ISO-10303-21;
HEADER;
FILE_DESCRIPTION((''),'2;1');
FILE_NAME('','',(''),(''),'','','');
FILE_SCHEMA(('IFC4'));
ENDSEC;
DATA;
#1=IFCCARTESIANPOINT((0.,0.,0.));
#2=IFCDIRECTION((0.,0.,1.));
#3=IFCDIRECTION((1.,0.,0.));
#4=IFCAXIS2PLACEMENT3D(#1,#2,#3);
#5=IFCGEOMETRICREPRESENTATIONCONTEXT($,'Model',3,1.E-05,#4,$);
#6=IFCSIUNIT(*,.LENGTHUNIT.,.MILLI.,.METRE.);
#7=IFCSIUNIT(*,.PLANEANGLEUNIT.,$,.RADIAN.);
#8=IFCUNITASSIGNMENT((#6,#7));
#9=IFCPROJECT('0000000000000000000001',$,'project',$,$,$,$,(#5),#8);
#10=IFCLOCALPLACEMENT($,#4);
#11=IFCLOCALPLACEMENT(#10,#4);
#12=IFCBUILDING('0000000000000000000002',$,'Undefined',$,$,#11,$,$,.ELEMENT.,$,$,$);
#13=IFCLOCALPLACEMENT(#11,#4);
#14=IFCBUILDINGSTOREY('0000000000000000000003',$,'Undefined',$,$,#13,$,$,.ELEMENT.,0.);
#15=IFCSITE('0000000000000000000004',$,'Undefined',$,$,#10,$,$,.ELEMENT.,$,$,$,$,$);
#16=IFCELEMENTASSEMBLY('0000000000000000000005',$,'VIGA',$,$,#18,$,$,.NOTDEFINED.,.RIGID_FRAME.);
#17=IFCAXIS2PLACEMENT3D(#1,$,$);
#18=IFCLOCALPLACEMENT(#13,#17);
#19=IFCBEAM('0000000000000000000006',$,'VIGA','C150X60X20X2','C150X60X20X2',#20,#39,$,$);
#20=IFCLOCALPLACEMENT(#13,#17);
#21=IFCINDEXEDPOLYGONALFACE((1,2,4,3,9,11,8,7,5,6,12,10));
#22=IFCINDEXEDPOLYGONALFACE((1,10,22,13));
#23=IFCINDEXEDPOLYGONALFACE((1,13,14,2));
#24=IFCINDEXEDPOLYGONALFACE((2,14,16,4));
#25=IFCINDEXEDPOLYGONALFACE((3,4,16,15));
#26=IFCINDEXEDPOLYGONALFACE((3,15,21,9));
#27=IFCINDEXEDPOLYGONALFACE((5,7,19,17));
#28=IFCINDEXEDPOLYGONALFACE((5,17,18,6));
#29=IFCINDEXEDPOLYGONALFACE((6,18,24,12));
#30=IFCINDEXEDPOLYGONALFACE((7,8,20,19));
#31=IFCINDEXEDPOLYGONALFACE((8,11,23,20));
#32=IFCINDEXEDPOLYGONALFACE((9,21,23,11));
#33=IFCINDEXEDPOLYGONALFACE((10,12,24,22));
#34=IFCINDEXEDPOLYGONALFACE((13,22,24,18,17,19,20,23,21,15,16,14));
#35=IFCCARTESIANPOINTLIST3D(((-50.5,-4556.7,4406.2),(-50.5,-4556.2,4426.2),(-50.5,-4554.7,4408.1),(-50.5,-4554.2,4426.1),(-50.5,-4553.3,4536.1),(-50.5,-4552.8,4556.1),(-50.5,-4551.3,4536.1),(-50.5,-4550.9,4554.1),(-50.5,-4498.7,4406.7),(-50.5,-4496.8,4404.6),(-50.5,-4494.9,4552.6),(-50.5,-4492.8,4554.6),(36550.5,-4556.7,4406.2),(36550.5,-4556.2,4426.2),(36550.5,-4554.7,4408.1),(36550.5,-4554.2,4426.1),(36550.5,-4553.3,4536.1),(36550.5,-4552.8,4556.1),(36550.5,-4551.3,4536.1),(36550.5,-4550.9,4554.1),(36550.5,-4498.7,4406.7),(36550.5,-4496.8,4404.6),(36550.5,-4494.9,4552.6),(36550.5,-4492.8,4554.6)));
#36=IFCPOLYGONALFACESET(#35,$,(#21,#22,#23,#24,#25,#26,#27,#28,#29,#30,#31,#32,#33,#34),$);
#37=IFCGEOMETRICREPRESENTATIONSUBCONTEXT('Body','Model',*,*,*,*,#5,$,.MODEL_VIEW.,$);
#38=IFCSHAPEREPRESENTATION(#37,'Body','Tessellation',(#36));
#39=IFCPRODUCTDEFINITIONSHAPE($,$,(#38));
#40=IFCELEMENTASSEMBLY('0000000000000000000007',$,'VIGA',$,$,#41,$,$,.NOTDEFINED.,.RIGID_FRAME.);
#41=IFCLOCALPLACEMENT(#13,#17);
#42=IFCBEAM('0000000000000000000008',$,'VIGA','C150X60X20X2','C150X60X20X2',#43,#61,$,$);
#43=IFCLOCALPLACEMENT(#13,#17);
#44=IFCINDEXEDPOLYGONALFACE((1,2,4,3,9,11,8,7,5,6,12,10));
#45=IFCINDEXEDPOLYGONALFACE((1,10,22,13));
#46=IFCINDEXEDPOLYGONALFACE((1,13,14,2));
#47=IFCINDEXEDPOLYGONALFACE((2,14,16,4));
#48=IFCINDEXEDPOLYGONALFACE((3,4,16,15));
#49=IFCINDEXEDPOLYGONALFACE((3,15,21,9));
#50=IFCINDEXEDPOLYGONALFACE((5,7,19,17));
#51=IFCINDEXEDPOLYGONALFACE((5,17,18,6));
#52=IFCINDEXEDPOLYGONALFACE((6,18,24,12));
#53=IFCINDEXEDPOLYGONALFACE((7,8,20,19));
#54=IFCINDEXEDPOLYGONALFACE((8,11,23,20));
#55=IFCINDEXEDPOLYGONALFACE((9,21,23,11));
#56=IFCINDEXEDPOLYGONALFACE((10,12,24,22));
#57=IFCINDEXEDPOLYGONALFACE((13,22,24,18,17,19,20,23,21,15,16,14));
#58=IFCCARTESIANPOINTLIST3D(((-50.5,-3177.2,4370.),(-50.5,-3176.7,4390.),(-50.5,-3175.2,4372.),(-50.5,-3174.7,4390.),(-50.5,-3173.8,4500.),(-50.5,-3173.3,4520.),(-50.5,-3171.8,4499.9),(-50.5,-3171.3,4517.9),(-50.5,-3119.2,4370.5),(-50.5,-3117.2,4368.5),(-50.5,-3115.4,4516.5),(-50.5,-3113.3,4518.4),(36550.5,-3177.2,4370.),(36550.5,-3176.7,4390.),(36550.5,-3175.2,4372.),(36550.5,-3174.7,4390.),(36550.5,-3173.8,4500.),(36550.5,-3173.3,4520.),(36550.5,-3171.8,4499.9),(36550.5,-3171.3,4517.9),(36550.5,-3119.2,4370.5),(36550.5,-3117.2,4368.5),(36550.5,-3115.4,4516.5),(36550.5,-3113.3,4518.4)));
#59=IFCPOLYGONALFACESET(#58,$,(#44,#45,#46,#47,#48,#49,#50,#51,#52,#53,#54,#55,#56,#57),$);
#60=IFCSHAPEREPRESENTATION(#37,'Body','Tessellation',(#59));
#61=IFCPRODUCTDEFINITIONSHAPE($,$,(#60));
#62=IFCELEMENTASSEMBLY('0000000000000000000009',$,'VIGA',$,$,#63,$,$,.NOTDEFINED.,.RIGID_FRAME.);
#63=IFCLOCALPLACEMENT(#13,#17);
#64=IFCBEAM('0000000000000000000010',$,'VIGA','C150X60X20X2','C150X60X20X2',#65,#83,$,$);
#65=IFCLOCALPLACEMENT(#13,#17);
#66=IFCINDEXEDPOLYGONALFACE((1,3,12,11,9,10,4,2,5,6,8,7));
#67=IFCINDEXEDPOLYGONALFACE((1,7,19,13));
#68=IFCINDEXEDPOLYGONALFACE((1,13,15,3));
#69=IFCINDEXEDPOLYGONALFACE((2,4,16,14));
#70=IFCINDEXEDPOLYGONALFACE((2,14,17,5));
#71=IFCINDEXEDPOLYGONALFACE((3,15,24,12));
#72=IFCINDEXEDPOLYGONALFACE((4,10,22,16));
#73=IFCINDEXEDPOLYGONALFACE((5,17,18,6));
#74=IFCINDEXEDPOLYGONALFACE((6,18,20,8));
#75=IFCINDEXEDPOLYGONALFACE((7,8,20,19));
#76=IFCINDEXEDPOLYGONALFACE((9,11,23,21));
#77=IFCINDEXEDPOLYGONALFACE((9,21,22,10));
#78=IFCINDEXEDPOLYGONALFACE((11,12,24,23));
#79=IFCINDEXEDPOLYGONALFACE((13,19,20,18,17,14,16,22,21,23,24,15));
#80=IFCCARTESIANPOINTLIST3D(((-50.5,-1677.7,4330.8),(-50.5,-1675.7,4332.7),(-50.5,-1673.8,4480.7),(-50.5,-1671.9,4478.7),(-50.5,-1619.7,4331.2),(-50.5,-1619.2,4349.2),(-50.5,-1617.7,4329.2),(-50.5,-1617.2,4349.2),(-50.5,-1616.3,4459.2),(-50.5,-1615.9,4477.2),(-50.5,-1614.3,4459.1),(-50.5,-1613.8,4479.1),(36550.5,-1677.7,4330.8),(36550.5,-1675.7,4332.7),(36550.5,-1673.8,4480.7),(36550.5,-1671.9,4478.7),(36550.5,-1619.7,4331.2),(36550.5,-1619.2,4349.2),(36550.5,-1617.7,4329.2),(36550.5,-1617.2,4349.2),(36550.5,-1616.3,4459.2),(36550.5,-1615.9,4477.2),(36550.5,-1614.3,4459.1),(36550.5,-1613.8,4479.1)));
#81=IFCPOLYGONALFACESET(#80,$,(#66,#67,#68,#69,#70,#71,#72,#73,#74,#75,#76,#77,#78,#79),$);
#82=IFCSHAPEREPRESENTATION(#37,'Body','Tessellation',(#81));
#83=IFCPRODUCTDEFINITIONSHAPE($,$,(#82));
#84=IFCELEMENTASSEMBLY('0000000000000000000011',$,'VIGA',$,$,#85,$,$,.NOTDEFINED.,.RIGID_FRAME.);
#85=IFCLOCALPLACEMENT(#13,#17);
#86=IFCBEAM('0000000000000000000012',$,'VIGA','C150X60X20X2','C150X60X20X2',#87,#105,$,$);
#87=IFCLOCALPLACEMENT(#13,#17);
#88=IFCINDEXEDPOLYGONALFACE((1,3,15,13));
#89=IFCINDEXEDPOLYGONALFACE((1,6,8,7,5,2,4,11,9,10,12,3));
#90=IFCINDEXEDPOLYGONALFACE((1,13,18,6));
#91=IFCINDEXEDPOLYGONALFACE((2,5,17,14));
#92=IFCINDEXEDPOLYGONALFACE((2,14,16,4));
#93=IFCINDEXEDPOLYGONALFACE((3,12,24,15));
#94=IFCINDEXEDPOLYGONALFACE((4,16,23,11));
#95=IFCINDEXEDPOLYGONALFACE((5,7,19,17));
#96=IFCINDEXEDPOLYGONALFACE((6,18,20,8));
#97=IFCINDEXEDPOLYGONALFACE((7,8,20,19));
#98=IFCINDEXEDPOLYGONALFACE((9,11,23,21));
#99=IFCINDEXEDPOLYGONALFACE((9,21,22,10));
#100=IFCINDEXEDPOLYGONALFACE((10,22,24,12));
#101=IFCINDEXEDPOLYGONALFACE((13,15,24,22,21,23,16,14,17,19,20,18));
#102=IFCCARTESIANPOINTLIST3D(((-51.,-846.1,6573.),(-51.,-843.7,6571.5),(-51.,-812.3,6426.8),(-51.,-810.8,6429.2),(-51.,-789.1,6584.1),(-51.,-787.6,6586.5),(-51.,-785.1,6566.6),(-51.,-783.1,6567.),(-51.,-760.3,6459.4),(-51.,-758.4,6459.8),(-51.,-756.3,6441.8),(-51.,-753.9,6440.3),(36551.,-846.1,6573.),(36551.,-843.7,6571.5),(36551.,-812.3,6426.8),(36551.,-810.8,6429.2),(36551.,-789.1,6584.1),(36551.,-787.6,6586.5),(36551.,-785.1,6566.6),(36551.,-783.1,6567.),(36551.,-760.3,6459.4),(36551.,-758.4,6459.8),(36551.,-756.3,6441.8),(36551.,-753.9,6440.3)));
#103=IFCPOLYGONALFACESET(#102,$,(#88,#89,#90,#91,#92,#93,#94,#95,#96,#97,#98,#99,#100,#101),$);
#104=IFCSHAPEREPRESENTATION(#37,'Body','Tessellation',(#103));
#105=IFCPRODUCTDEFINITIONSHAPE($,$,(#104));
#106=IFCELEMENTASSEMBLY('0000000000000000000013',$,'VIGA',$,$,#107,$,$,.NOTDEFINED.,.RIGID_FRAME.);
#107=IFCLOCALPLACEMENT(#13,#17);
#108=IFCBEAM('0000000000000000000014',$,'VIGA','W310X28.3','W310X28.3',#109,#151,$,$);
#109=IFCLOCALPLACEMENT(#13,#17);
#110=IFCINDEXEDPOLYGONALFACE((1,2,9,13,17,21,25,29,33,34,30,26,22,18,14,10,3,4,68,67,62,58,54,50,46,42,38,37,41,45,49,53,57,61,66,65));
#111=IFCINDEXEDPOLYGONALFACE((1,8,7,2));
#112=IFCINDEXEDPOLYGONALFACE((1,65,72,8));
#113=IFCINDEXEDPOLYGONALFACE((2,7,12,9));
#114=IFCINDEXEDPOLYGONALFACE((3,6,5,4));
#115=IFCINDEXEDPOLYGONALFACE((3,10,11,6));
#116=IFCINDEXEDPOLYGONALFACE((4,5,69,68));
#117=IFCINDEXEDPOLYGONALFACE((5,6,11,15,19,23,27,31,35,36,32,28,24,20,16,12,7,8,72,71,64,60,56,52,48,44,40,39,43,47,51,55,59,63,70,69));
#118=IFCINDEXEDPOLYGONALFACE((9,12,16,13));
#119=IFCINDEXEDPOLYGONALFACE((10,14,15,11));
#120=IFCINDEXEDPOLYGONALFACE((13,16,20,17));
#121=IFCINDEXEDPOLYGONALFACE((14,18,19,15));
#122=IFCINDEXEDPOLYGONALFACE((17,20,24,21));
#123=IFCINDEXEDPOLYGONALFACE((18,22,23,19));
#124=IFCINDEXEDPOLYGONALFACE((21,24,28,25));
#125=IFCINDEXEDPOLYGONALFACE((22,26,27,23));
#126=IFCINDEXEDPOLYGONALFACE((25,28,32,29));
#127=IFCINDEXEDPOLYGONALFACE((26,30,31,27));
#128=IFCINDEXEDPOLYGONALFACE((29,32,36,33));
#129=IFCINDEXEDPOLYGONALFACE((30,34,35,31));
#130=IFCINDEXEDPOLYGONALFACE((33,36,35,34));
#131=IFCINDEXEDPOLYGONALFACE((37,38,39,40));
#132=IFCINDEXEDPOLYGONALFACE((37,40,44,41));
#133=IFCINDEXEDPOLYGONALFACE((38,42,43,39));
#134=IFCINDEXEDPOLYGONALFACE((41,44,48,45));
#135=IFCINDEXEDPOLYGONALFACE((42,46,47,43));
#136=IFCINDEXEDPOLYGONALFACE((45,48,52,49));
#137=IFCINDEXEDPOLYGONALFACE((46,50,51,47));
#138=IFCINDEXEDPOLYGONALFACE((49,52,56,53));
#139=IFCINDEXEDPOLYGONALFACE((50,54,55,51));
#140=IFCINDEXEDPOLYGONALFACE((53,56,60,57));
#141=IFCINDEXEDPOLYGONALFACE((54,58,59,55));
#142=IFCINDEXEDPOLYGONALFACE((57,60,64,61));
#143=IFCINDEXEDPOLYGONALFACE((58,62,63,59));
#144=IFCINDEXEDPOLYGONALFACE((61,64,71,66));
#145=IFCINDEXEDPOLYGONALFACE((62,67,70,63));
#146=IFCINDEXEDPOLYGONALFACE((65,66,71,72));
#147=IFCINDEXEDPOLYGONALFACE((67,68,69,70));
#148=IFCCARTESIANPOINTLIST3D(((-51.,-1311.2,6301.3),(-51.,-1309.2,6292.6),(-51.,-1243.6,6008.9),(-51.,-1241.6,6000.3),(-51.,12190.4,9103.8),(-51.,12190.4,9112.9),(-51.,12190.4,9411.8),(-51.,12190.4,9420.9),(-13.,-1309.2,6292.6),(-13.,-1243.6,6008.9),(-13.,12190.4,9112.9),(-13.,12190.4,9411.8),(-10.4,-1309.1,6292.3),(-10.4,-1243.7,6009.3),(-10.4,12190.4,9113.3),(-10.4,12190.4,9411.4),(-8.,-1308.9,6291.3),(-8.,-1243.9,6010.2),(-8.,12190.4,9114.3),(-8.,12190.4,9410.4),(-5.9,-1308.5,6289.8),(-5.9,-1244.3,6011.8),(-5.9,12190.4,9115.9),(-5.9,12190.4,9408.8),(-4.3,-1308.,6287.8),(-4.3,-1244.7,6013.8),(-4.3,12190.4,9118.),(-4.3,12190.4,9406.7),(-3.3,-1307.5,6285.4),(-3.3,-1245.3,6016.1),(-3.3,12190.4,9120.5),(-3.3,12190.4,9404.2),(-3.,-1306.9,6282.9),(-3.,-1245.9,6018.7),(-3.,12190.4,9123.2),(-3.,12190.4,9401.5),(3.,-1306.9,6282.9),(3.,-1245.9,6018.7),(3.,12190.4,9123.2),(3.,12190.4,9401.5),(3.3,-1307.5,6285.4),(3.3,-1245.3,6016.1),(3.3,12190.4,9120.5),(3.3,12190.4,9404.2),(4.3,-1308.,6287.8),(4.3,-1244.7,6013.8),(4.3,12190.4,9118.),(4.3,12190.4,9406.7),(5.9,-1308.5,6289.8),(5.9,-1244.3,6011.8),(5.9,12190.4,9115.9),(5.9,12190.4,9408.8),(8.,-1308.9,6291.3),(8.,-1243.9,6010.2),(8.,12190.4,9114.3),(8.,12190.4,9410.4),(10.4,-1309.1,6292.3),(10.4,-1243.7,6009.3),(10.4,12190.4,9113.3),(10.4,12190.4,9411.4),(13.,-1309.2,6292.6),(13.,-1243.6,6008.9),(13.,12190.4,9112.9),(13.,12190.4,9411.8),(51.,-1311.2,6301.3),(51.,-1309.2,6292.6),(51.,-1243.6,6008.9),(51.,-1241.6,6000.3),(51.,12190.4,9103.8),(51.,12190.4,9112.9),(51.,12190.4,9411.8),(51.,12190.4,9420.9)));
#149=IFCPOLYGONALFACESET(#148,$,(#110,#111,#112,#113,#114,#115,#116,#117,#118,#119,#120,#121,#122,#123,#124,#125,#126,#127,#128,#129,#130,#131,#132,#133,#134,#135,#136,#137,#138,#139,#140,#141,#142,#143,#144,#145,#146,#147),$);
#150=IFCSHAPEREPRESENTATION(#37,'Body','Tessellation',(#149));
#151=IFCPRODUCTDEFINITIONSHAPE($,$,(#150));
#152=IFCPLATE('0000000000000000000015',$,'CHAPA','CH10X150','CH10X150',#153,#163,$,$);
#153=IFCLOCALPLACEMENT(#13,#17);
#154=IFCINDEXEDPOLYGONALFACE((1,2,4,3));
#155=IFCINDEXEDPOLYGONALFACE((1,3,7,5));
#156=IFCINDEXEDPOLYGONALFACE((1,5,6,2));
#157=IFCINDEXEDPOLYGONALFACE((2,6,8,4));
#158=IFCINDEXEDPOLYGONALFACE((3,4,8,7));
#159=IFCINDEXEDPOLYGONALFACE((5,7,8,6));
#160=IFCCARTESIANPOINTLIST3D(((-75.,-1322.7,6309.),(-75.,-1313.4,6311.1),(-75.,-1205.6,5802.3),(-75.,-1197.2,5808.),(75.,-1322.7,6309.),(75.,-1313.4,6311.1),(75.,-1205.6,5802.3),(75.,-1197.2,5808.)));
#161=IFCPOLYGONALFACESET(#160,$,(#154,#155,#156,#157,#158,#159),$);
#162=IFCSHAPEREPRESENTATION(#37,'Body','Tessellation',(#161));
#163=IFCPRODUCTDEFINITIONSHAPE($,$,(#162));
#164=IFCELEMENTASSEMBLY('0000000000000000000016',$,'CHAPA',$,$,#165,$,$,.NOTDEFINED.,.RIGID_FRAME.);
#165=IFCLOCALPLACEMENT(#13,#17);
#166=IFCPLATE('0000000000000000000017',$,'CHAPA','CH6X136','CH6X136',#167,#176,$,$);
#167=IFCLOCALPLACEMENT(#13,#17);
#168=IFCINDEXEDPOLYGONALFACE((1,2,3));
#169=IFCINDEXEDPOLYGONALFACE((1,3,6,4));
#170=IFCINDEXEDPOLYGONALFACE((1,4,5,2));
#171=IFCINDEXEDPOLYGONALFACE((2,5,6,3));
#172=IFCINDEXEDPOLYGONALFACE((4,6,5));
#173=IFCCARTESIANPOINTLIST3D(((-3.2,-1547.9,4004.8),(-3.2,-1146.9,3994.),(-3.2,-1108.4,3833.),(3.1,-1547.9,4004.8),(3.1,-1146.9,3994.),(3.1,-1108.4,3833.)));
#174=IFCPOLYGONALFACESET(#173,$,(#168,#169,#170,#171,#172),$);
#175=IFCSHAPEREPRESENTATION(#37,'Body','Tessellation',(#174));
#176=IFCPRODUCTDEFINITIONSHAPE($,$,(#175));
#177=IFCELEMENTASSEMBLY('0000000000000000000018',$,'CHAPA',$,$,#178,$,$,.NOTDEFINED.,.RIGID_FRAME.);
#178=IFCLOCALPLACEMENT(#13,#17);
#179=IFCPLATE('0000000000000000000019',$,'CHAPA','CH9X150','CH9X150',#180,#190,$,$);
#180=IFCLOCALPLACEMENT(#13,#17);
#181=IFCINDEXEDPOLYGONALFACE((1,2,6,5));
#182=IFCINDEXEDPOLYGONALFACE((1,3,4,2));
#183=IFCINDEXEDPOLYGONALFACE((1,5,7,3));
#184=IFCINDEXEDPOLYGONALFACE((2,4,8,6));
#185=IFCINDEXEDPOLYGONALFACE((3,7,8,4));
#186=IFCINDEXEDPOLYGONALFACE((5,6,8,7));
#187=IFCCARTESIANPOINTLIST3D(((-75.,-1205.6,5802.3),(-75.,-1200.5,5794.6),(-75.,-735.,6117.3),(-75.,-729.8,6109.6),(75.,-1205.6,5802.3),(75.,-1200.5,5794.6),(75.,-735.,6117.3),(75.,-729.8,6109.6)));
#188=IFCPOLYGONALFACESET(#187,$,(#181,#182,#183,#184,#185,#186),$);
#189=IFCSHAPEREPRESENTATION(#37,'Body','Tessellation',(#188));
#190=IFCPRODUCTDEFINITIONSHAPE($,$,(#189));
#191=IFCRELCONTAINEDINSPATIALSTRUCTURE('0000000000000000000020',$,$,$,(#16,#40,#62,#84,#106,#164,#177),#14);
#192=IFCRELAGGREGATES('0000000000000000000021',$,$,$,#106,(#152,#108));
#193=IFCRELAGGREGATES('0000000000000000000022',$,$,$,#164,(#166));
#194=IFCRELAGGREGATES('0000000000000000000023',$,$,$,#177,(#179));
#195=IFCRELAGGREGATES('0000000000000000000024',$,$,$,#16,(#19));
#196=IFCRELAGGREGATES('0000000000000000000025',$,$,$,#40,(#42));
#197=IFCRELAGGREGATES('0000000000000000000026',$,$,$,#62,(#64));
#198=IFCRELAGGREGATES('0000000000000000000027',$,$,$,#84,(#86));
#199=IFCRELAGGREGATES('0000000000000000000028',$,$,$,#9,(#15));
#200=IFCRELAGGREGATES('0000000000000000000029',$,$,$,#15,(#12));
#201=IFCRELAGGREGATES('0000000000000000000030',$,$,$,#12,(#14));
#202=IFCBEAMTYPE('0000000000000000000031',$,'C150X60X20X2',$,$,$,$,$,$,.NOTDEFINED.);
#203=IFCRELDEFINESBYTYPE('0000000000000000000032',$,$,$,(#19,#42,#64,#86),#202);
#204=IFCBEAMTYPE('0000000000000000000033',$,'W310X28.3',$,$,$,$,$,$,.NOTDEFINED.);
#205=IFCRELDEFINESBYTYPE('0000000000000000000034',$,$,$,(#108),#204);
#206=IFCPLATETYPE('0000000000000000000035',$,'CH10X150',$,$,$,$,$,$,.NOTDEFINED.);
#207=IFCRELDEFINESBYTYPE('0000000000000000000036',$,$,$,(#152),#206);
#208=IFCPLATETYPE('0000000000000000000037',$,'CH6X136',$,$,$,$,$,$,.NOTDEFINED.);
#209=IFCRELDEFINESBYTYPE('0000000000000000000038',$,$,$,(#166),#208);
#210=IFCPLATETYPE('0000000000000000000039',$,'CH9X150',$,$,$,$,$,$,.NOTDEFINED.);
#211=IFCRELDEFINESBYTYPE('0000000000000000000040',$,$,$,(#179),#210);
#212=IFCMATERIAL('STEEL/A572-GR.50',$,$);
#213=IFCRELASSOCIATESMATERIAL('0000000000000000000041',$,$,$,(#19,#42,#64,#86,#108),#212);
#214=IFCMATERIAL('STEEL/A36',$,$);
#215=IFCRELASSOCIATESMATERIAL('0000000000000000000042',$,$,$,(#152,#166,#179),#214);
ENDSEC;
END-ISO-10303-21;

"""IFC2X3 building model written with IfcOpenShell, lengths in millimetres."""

from ifc_helpers import new_model, si_unit, frame, origin_with_axes, origin_2d_with_axis, place, context, subcontext, project, spatial, polyline, i_section, c_section, outline, extrude, clip, halfspace, material, type_object, element, aggregate, save


model = new_model("IFC2X3")

# Units and contexts
model_context = context("Model", 3, precision=1e-05, world=origin_with_axes())
body_context = subcontext(model_context, "Body", "Model", "MODEL_VIEW")
ifc_project = project(units=[si_unit("LENGTHUNIT", "METRE", prefix="MILLI"), si_unit("PLANEANGLEUNIT", "RADIAN")], contexts=[model_context])

# Site, building, storey
site_placement = place(None, origin_with_axes())
site = spatial("IfcSite", under=ifc_project, at=site_placement, Name="Undefined", CompositionType="ELEMENT")
building_placement = place(site_placement, origin_with_axes())
building = spatial("IfcBuilding", under=site, at=building_placement, Name="Undefined", CompositionType="ELEMENT")
storey_placement = place(building_placement, origin_with_axes())
storey = spatial("IfcBuildingStorey", under=building, at=storey_placement, Name="Undefined", CompositionType="ELEMENT", Elevation=0.0)

# Element assemblies, beams
assembly_1_placement = place(storey_placement, origin_with_axes())
assembly_1 = element("IfcElementAssembly", 1, at=assembly_1_placement, inside=storey, Name="VIGA", AssemblyPlace="NOTDEFINED", PredefinedType="RIGID_FRAME")
ifc_material_1 = material(Name="STEEL/A572-GR.50")
beam_type_1 = type_object("IfcBeamType", Name="C150X60X20X2", PredefinedType="NOTDEFINED")
beam_1_placement = place(assembly_1_placement, frame((-50.5, -4524.8, 4480.4), z_axis=(0.0, 0.026187, 0.999657), x_axis=(1.0, 0.0, 0.0)))
beam_1 = element("IfcBeam", 2, at=beam_1_placement, type_object=beam_type_1, material=ifc_material_1, Name="VIGA", Description="C150X60X20X2", ObjectType="C150X60X20X2", context=body_context, shape_type="SweptSolid", body=[
    extrude(c_section(Depth=150.0, Width=60.0, WallThickness=2.0, Girth=20.0, at=origin_2d_with_axis()), frame((36601.0, 0.0, 0.0), z_axis=(-1.0, 0.0, 0.0), x_axis=(0.0, -1.0, 0.0)), (0.0, 0.0, 1.0), 36601.0),
])
assembly_2_placement = place(storey_placement, origin_with_axes())
assembly_2 = element("IfcElementAssembly", 3, at=assembly_2_placement, inside=storey, Name="VIGA", AssemblyPlace="NOTDEFINED", PredefinedType="RIGID_FRAME")
beam_2_placement = place(assembly_2_placement, frame((-50.5, -3145.3, 4444.2), z_axis=(0.0, 0.026187, 0.999657), x_axis=(1.0, 0.0, 0.0)))
beam_2 = element("IfcBeam", 4, at=beam_2_placement, type_object=beam_type_1, material=ifc_material_1, Name="VIGA", Description="C150X60X20X2", ObjectType="C150X60X20X2", context=body_context, shape_type="SweptSolid", body=[
    extrude(c_section(Depth=150.0, Width=60.0, WallThickness=2.0, Girth=20.0, at=origin_2d_with_axis()), frame((36601.0, 0.0, 0.0), z_axis=(-1.0, 0.0, 0.0), x_axis=(0.0, -1.0, 0.0)), (0.0, 0.0, 1.0), 36601.0),
])
assembly_3_placement = place(storey_placement, origin_with_axes())
assembly_3 = element("IfcElementAssembly", 5, at=assembly_3_placement, inside=storey, Name="VIGA", AssemblyPlace="NOTDEFINED", PredefinedType="RIGID_FRAME")
beam_3_placement = place(assembly_3_placement, frame((-50.5, -1645.8, 4404.9), z_axis=(0.0, -0.026187, -0.999657), x_axis=(1.0, 0.0, 0.0)))
beam_3 = element("IfcBeam", 6, at=beam_3_placement, type_object=beam_type_1, material=ifc_material_1, Name="VIGA", Description="C150X60X20X2", ObjectType="C150X60X20X2", context=body_context, shape_type="SweptSolid", body=[
    extrude(c_section(Depth=150.0, Width=60.0, WallThickness=2.0, Girth=20.0, at=origin_2d_with_axis()), frame((36601.0, 0.0, 0.0), z_axis=(-1.0, 0.0, 0.0), x_axis=(0.0, -1.0, 0.0)), (0.0, 0.0, 1.0), 36601.0),
])
assembly_4_placement = place(storey_placement, origin_with_axes())
assembly_4 = element("IfcElementAssembly", 7, at=assembly_4_placement, inside=storey, Name="VIGA", AssemblyPlace="NOTDEFINED", PredefinedType="RIGID_FRAME")
beam_4_placement = place(assembly_4_placement, frame((-51.0, -800.0, 6506.7), z_axis=(0.0, 0.225124, -0.97433), x_axis=(1.0, 0.0, 0.0)))
beam_4 = element("IfcBeam", 8, at=beam_4_placement, type_object=beam_type_1, material=ifc_material_1, Name="VIGA", Description="C150X60X20X2", ObjectType="C150X60X20X2", context=body_context, shape_type="SweptSolid", body=[
    extrude(c_section(Depth=150.0, Width=60.0, WallThickness=2.0, Girth=20.0, at=origin_2d_with_axis()), frame((36602.0, 0.0, 0.0), z_axis=(-1.0, 0.0, 0.0), x_axis=(0.0, -1.0, 0.0)), (0.0, 0.0, 1.0), 36602.0),
])
assembly_5_placement = place(storey_placement, origin_with_axes())
assembly_5 = element("IfcElementAssembly", 9, at=assembly_5_placement, inside=storey, Name="VIGA", AssemblyPlace="NOTDEFINED", PredefinedType="RIGID_FRAME")
beam_type_2 = type_object("IfcBeamType", Name="W310X28.3", PredefinedType="NOTDEFINED")
beam_5_placement = place(assembly_5_placement, frame((0.0, -1276.4, 6150.8), z_axis=(0.0, 0.225124, -0.97433), x_axis=(0.0, 0.97433, 0.225124)))
beam_5 = element("IfcBeam", 10, at=beam_5_placement, type_object=beam_type_2, material=ifc_material_1, Name="VIGA", Description="W310X28.3", ObjectType="W310X28.3", context=body_context, shape_type="Clipping", body=[
    clip(extrude(i_section(OverallWidth=102.0, OverallDepth=309.0, WebThickness=6.0, FlangeThickness=8.9, FilletRadius=10.0, at=origin_2d_with_axis()), frame((13995.7, 0.0, 0.0), z_axis=(-1.0, 0.0, 0.0), x_axis=(0.0, -1.0, 0.0)), (0.0, 0.0, 1.0), 13995.7), halfspace(frame((13857.8, 0.0, -156.7), z_axis=(0.97433, 0.0, 0.225124), x_axis=(-0.225124, 0.0, 0.97433)), False)),
])

# Plate
ifc_material_2 = material(Name="STEEL/A36")
plate_type_1 = type_object("IfcPlateType", Name="CH10X150", PredefinedType="NOTDEFINED")
plate_1_placement = place(assembly_5_placement, frame((75.0, -1318.1, 6310.1), z_axis=(0.0, 0.97433, 0.225124), x_axis=(0.0, 0.225124, -0.97433)))
plate_1 = element("IfcPlate", 11, at=plate_1_placement, type_object=plate_type_1, material=ifc_material_2, Name="CHAPA", Description="CH10X150", ObjectType="CH10X150", context=body_context, shape_type="Clipping", body=[
    clip(extrude(outline(polyline([(0.0, 0.0), (520.0, 0.0), (520.0, 150.0), (0.0, 150.0), (0.0, 0.0)])), frame((0.0, 0.0, -4.8), z_axis=(0.0, 0.0, 1.0), x_axis=(1.0, 0.0, 0.0)), (0.0, 0.0, 1.0), 9.5), halfspace(frame((516.4, -500.0, 4.8), z_axis=(0.934951, 0.0, 0.354778), x_axis=(0.0, 1.0, 0.0)), False)),
])
aggregate(assembly_5, [plate_1, beam_5])

# Element assemblies, plates
assembly_6_placement = place(storey_placement, origin_with_axes())
assembly_6 = element("IfcElementAssembly", 12, at=assembly_6_placement, inside=storey, Name="CHAPA", AssemblyPlace="NOTDEFINED", PredefinedType="RIGID_FRAME")
plate_type_2 = type_object("IfcPlateType", Name="CH6X136", PredefinedType="NOTDEFINED")
plate_2_placement = place(assembly_6_placement, frame((0.0, -1146.9, 3994.0), z_axis=(1.0, 0.0, 0.0), x_axis=(0.0, -0.999636, 0.026972)))
plate_2 = element("IfcPlate", 13, at=plate_2_placement, type_object=plate_type_2, material=ifc_material_2, Name="CHAPA", Description="CH6X136", ObjectType="CH6X136", context=body_context, shape_type="SweptSolid", body=[
    extrude(outline(polyline([(0.0, 0.0), (401.1, 0.0), (-42.8, 159.9), (0.0, 0.0)])), frame((0.0, 0.0, -3.1), z_axis=(0.0, 0.0, 1.0), x_axis=(1.0, 0.0, 0.0)), (0.0, 0.0, 1.0), 6.3),
])
aggregate(assembly_6, [plate_2])
assembly_7_placement = place(storey_placement, origin_with_axes())
assembly_7 = element("IfcElementAssembly", 14, at=assembly_7_placement, inside=storey, Name="CHAPA", AssemblyPlace="NOTDEFINED", PredefinedType="RIGID_FRAME")
plate_type_3 = type_object("IfcPlateType", Name="CH9X150", PredefinedType="NOTDEFINED")
plate_3_placement = place(assembly_7_placement, frame((75.0, -732.4, 6113.5), z_axis=(0.0, -0.55615, 0.831082), x_axis=(-1.0, 0.0, 0.0)))
plate_3 = element("IfcPlate", 15, at=plate_3_placement, type_object=plate_type_3, material=ifc_material_2, Name="CHAPA", Description="CH9X150", ObjectType="CH9X150", context=body_context, shape_type="SweptSolid", body=[
    extrude(outline(polyline([(0.0, 0.0), (150.0, 0.0), (150.0, 566.3), (0.0, 566.3), (0.0, 0.0)])), frame((0.0, 0.0, -4.7), z_axis=(0.0, 0.0, 1.0), x_axis=(1.0, 0.0, 0.0)), (0.0, 0.0, 1.0), 9.3),
])
aggregate(assembly_7, [plate_3])

aggregate(assembly_1, [beam_1])
aggregate(assembly_2, [beam_2])
aggregate(assembly_3, [beam_3])
aggregate(assembly_4, [beam_4])

save(model, "model.ifc")
